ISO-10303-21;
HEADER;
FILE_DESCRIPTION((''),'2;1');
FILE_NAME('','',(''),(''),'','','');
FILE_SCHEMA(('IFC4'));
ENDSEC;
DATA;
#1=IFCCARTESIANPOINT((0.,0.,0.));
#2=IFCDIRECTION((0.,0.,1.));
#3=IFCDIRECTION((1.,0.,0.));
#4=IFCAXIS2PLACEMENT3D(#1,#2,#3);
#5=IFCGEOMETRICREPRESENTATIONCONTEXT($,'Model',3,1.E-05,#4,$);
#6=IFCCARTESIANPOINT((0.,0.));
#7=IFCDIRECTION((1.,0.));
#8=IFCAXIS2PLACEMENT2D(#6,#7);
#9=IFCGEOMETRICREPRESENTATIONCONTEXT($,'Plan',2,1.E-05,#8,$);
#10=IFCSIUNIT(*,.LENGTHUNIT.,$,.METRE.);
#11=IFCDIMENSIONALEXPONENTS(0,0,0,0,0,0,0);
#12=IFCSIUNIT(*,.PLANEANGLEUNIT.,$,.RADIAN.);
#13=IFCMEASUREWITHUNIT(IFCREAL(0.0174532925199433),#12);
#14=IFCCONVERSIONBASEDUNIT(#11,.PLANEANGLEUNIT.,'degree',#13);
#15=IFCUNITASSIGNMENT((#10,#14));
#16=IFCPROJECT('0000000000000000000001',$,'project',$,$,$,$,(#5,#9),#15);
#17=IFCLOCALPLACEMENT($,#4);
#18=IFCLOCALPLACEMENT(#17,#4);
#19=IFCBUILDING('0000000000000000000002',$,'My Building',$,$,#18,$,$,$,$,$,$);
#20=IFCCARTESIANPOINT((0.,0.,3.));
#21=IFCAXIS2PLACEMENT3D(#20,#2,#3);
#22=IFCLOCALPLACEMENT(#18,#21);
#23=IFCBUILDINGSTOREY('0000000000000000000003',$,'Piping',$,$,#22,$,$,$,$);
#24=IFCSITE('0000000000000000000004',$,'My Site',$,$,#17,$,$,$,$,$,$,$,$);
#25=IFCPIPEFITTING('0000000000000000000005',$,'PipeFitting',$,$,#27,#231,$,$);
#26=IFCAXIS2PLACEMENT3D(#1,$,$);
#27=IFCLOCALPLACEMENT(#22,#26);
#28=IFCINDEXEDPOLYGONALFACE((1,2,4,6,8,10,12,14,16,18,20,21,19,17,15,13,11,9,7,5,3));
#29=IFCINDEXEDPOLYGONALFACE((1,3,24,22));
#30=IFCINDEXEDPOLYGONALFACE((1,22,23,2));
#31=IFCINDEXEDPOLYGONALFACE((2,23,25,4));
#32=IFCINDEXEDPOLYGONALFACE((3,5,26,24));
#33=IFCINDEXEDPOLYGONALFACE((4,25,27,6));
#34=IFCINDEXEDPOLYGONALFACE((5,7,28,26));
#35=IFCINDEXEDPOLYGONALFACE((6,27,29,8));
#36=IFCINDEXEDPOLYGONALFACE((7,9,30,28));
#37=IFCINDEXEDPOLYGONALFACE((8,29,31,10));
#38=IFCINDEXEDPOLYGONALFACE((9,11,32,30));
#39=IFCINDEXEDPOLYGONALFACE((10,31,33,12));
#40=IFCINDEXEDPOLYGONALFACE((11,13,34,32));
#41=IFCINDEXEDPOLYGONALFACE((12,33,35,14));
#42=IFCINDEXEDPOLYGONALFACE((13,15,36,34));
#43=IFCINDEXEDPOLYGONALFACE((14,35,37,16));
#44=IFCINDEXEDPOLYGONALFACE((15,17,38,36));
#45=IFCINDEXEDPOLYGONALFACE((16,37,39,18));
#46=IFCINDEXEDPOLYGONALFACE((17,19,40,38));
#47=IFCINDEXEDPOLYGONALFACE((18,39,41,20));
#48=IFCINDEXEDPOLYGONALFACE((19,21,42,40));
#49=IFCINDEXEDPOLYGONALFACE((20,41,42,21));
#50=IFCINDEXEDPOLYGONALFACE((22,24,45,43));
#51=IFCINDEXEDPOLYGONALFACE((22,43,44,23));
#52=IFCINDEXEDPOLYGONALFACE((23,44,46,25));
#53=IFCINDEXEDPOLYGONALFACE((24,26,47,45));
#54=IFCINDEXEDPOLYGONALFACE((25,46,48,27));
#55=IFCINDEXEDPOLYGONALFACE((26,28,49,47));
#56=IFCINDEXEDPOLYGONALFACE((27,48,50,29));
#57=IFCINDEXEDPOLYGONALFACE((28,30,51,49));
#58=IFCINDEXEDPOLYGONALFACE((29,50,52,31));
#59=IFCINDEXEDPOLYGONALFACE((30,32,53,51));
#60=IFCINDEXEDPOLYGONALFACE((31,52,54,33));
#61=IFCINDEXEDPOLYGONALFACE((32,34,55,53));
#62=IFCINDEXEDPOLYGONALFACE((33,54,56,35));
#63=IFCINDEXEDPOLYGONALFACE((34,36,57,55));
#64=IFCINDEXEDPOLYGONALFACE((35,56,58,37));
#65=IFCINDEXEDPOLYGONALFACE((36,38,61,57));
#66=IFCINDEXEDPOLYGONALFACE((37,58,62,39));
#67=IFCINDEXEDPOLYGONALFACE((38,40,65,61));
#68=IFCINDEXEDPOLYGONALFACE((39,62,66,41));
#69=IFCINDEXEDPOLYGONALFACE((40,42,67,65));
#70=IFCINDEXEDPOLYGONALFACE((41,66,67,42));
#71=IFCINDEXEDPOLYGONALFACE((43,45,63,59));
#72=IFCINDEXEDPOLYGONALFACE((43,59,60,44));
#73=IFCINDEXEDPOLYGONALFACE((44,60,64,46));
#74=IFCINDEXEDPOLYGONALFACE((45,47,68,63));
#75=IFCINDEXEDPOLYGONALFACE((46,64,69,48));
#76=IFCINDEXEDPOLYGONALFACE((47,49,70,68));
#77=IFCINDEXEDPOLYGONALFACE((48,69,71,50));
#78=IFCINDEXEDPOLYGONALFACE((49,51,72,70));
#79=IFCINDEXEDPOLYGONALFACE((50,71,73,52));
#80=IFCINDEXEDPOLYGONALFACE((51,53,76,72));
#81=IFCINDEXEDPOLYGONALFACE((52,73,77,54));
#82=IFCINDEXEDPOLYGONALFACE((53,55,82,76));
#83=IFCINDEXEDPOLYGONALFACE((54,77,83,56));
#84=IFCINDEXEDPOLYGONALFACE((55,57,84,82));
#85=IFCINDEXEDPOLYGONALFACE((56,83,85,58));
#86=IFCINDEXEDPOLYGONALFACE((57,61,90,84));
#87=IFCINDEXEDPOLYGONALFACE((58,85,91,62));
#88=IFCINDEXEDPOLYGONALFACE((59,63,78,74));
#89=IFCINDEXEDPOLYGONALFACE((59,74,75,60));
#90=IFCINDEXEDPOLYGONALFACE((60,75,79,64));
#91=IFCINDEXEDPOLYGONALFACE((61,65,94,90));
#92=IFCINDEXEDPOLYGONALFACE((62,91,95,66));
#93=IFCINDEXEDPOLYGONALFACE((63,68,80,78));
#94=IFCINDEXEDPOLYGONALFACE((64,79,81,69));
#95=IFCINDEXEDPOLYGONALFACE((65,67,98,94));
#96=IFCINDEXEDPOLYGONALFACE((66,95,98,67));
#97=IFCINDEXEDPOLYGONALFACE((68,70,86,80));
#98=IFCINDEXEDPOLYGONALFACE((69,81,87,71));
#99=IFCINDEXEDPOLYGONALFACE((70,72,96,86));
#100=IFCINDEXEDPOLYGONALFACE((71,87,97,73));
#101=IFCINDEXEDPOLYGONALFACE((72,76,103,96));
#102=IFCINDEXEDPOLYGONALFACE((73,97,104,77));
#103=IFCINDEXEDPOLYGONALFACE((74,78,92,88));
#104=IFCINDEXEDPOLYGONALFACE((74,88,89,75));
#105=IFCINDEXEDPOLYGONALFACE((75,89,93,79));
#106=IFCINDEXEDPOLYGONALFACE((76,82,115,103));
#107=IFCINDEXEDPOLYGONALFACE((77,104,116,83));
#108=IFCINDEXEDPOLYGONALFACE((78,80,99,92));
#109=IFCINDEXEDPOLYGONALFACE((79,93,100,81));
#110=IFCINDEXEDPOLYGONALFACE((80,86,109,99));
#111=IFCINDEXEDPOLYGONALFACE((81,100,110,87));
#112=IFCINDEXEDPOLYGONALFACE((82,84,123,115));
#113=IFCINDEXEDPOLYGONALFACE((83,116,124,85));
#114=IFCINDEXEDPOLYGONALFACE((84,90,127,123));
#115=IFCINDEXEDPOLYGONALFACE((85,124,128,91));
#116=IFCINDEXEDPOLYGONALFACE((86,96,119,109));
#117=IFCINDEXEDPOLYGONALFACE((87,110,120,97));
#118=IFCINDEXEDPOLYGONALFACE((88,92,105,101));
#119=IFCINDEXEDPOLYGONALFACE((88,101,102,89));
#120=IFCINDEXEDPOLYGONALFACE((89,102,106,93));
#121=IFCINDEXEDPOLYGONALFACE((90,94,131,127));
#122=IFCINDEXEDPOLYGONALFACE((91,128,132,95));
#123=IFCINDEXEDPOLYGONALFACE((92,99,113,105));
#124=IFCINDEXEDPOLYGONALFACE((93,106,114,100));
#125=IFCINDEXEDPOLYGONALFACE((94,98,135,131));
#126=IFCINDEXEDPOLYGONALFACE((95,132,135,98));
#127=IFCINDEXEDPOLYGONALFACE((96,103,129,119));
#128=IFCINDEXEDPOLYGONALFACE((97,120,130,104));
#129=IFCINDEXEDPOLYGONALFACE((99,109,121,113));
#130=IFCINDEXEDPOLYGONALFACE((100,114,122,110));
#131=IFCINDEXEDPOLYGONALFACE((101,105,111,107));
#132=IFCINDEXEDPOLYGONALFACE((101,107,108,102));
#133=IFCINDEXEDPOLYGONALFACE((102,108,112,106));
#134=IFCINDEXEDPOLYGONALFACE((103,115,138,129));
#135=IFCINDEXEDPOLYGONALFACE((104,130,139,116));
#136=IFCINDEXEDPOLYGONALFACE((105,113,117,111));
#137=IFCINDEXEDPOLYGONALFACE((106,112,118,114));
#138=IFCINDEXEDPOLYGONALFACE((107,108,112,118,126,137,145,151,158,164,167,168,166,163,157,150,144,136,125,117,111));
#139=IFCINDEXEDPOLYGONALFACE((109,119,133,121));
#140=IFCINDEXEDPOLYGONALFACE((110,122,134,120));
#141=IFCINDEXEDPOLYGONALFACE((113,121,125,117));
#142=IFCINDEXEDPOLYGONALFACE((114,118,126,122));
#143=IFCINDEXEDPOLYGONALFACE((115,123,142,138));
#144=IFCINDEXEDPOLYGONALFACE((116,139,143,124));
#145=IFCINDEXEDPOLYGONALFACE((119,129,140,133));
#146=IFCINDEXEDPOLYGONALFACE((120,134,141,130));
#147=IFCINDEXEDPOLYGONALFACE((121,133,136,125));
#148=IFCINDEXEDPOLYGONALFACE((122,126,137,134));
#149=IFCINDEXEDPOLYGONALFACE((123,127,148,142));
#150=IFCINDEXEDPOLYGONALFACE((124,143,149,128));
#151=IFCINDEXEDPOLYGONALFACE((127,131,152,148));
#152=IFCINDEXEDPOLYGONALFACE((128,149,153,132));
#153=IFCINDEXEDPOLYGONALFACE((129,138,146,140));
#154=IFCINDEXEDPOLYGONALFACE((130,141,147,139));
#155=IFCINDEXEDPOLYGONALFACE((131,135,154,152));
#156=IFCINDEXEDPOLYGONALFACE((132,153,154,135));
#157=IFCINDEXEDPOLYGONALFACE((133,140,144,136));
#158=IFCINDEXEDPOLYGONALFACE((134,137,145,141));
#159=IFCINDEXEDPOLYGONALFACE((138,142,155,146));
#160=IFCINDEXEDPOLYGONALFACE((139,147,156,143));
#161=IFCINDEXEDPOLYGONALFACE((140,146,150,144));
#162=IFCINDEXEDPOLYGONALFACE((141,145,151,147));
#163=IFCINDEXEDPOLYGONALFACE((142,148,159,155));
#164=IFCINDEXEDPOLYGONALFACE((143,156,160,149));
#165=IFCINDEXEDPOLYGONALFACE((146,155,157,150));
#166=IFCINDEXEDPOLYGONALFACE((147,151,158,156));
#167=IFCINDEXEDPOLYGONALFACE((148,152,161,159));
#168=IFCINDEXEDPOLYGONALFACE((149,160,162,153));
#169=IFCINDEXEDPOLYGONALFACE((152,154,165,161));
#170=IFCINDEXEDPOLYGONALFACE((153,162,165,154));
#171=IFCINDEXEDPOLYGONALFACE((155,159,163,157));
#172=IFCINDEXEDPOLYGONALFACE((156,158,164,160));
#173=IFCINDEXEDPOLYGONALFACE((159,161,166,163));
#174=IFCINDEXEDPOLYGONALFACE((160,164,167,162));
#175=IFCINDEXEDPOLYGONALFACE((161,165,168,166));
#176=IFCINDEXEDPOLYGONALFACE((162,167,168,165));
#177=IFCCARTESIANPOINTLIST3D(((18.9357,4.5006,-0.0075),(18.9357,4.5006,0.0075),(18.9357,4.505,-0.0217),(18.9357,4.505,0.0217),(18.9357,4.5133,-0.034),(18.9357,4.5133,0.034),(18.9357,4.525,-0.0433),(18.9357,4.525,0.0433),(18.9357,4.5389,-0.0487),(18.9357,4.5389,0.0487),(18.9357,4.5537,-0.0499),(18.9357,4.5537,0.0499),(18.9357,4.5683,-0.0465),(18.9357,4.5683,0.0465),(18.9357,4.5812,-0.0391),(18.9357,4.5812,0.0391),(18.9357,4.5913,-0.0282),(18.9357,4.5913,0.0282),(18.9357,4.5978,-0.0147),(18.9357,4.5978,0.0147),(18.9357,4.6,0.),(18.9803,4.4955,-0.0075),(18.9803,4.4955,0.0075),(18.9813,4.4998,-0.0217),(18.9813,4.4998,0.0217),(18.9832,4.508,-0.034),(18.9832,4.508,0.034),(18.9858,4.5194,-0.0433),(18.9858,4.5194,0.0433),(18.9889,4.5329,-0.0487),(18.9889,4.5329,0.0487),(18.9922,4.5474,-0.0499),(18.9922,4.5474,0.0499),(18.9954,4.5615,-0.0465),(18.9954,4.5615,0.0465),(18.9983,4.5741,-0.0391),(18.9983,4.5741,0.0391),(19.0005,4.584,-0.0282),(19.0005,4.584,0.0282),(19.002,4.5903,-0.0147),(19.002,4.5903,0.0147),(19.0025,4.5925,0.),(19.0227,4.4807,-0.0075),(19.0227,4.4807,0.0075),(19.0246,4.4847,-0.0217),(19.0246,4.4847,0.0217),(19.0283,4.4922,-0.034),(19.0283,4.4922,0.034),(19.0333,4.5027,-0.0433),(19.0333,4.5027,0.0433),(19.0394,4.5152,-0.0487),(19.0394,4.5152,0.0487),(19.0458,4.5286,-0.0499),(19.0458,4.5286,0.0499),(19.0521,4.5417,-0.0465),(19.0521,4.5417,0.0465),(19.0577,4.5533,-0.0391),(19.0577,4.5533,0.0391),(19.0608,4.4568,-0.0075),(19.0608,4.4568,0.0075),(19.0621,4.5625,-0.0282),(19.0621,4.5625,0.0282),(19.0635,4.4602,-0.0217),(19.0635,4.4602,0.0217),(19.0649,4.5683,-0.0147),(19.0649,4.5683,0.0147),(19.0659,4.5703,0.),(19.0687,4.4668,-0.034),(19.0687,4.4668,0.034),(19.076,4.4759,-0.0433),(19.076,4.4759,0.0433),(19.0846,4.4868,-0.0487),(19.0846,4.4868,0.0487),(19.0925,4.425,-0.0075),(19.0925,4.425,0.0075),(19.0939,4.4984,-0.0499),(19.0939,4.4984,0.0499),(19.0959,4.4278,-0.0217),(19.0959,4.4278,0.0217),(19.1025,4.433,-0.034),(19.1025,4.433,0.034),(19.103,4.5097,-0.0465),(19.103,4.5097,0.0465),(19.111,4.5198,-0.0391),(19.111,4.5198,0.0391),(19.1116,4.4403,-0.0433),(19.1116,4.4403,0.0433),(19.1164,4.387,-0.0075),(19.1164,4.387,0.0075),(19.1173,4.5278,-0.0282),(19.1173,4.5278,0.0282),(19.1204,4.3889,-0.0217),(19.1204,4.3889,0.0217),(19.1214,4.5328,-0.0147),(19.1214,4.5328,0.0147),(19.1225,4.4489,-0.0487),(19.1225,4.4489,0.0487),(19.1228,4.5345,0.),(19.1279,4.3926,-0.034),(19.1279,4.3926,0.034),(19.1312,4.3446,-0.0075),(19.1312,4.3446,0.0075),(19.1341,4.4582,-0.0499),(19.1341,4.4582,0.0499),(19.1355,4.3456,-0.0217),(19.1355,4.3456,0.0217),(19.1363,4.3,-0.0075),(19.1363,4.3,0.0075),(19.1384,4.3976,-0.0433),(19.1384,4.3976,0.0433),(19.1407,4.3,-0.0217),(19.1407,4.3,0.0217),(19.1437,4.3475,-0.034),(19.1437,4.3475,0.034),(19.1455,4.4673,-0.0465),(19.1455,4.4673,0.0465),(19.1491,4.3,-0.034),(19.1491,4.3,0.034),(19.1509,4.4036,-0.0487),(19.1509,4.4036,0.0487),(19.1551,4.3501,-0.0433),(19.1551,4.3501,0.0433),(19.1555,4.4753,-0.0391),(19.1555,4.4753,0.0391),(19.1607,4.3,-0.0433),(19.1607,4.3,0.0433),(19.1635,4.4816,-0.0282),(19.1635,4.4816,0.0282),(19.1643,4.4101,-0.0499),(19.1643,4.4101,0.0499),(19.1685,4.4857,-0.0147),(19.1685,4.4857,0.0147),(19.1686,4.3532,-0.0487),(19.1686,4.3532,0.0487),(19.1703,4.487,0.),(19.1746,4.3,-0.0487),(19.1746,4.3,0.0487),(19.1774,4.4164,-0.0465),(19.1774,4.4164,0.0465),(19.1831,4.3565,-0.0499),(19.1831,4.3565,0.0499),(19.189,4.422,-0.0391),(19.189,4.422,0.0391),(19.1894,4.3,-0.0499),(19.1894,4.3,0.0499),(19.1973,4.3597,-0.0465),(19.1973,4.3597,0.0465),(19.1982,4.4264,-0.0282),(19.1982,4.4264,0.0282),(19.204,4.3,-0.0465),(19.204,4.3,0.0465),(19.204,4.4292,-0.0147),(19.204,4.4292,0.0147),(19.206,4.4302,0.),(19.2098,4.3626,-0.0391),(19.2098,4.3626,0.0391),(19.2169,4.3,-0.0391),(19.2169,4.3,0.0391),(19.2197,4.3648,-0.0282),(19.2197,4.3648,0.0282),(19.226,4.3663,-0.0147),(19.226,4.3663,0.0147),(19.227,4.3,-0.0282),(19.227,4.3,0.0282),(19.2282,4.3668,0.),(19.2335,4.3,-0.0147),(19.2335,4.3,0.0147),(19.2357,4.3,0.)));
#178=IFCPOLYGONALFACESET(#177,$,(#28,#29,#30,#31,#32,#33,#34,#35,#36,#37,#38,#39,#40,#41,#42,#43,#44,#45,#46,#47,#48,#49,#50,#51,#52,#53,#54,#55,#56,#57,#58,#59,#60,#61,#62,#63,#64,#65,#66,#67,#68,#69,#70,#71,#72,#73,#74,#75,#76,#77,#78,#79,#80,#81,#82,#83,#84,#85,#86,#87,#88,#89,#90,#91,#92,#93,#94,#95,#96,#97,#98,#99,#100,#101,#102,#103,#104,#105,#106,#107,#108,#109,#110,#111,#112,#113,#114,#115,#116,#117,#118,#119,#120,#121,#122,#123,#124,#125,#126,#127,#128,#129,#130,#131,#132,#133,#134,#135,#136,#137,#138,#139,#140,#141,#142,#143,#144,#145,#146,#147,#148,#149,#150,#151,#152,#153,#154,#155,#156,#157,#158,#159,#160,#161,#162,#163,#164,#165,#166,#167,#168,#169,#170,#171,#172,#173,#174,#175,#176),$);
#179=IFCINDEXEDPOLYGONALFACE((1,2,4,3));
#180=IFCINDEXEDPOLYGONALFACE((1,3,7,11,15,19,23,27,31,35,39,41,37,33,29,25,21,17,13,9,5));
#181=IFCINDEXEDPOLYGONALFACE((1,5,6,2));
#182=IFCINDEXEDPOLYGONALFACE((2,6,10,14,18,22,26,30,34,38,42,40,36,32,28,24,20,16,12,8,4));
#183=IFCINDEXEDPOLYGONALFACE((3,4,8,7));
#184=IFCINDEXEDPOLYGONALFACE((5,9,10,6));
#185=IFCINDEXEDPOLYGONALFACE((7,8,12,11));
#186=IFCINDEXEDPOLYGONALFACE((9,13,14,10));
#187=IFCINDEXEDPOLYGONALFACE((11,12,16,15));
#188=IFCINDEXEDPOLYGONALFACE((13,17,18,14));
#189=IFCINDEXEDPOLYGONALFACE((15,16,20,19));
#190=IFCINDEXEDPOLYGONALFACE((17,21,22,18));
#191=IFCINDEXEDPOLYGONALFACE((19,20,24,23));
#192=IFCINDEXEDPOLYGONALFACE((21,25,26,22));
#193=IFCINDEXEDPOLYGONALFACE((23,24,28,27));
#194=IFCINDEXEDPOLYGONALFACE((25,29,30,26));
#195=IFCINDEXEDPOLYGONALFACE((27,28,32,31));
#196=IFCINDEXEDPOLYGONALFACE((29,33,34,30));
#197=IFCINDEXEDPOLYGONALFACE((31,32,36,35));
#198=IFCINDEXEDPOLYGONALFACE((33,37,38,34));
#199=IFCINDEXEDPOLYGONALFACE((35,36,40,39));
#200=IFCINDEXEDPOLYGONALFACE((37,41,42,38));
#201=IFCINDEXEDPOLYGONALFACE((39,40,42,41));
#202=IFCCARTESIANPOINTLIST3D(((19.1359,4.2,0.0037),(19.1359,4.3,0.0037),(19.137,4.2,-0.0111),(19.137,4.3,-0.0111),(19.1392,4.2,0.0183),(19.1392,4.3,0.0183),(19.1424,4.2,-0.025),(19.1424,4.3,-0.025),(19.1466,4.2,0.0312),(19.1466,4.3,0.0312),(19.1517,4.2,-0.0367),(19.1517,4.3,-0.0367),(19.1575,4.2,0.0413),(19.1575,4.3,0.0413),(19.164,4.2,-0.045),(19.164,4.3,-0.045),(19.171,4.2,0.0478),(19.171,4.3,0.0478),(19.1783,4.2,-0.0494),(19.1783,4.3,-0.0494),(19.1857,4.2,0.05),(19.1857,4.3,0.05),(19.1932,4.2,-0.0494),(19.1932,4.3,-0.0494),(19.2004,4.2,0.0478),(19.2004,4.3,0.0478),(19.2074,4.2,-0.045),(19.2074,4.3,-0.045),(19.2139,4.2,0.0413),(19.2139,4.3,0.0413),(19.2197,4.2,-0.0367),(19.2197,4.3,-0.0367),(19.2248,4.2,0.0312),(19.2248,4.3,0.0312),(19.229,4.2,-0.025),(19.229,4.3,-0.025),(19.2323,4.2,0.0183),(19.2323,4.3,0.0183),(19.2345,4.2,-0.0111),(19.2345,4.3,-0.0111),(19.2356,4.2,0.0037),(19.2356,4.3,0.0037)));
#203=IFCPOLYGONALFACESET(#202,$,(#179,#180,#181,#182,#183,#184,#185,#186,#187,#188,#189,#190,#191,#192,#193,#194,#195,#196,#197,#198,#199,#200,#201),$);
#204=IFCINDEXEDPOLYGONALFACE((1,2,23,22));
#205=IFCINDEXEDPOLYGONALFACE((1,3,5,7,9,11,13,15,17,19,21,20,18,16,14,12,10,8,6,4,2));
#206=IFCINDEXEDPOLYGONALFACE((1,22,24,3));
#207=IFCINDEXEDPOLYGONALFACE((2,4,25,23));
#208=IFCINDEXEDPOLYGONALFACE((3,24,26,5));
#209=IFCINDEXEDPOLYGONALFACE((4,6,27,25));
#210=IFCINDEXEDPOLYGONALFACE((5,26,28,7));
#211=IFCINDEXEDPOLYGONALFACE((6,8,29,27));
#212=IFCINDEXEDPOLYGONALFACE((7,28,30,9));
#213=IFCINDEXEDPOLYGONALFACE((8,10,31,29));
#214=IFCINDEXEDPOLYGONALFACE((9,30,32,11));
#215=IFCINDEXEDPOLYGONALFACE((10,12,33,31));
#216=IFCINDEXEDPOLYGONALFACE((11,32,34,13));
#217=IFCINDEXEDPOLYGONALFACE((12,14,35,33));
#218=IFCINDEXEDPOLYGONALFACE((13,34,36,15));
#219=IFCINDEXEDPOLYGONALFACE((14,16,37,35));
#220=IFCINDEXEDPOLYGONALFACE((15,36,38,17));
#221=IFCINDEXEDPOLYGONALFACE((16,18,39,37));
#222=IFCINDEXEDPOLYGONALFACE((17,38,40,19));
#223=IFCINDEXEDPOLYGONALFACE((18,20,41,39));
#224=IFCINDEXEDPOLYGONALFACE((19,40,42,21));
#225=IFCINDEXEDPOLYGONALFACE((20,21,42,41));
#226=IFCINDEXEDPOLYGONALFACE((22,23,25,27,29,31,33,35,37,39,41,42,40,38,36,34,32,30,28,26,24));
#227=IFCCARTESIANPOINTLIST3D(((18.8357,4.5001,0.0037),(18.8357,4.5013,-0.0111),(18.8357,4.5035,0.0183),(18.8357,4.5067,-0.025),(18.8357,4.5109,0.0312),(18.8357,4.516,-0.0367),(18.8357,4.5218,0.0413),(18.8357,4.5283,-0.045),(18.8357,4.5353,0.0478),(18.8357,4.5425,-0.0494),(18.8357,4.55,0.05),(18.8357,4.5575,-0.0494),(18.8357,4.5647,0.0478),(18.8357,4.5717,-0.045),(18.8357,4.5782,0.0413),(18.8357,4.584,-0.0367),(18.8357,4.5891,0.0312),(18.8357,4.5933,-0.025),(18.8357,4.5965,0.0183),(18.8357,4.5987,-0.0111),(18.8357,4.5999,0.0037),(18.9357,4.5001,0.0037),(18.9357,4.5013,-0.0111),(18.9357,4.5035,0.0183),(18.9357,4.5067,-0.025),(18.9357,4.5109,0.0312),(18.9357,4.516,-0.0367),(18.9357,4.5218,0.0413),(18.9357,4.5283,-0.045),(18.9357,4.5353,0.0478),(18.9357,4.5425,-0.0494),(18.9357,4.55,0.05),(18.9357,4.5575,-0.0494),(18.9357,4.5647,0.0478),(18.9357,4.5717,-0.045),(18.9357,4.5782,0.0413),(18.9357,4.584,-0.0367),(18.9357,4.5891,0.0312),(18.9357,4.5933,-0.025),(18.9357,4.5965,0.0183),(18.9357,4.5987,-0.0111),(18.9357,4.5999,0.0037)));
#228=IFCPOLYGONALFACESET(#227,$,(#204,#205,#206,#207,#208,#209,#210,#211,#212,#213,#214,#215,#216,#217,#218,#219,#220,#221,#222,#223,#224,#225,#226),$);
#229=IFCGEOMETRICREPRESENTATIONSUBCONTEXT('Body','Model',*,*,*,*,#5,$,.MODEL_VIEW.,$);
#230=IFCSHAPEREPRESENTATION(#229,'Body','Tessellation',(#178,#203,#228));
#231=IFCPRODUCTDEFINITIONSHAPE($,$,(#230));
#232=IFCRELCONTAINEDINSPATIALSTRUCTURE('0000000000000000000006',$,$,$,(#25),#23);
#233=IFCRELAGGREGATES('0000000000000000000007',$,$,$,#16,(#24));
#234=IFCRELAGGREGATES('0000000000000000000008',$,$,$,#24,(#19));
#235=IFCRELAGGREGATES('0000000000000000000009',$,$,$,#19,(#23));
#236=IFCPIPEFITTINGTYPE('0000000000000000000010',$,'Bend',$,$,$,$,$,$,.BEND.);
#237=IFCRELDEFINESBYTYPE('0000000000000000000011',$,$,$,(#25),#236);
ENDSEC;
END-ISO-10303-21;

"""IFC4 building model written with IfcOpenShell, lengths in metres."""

from ifc_helpers import new_model, entity, si_unit, converted_unit, frame, origin_with_axes, origin_2d_with_axis, place, context, subcontext, project, spatial, line, indexed_curve, circle, outline, extrude, source, transform, mapped, type_object, type_shapes, element, save


model = new_model("IFC4")

# Units and contexts
model_context = context("Model", 3, precision=1e-05, world=origin_with_axes())
plan_context = context("Plan", 2, precision=1e-05, world=origin_2d_with_axis())
body_context = subcontext(model_context, "Body", "Model", "MODEL_VIEW")
ifc_project = project(units=[si_unit("LENGTHUNIT", "METRE"), converted_unit("PLANEANGLEUNIT", "degree", entity("IfcReal", 0.0174532925199433), si_unit("PLANEANGLEUNIT", "RADIAN"), dimensions=[0, 0, 0, 0, 0, 0, 0])], contexts=[model_context, plan_context])

# Site, building, storey
site_placement = place(None, origin_with_axes())
site = spatial("IfcSite", under=ifc_project, at=site_placement, Name="My Site")
building_placement = place(site_placement, origin_with_axes())
building = spatial("IfcBuilding", under=site, at=building_placement, Name="My Building")
storey_placement = place(building_placement, frame((0.0, 0.0, 3.0), z_axis=(0.0, 0.0, 1.0), x_axis=(1.0, 0.0, 0.0)))
storey = spatial("IfcBuildingStorey", under=building, at=storey_placement, Name="Piping")

# Pipe fitting, opening
pipe_fitting_type = type_object("IfcPipeFittingType", Name="Bend", PredefinedType="BEND")
shared_shape = source(origin_with_axes(), body_context, "Body", "SolidModel", [
    entity("IfcSweptDiskSolid", entity("IfcIndexedPolyCurve", entity("IfcCartesianPointList3D", [[0.0, 0.0, 0.1], [0.0, -0.0732, 0.2768], [0.0, -0.25, 0.35]]), [entity("IfcArcIndex", [1, 2, 3])]), 0.05),
    extrude(circle(Radius=0.05), origin_with_axes(), (0.0, 0.0, 1.0), 0.1),
    extrude(circle(Radius=0.05), frame((0.0, -0.25, 0.35), z_axis=(0.0, -1.0, 0.0), x_axis=(1.0, 0.0, 0.0)), (0.0, 0.0, 1.0), 0.1),
])
type_shapes(pipe_fitting_type, [shared_shape])
pipe_fitting_1_placement = place(storey_placement, frame((19.1857, 4.2, 0.0), z_axis=(0.0, 1.0, 0.0), x_axis=(0.0, 0.0, 1.0)))
pipe_fitting_1 = element("IfcPipeFitting", 1, at=pipe_fitting_1_placement, inside=storey, type_object=pipe_fitting_type, Name="PipeFitting", context=body_context, shape_type="MappedRepresentation", body=[
    mapped(shared_shape, transform((0.0, 0.0, 0.0), x_axis=(1.0, 0.0, 0.0), y_axis=(0.0, 1.0, 0.0), z_axis=(0.0, 0.0, 1.0), scale=1.0)),
])
opening_1_placement = place(pipe_fitting_1_placement, frame((-3.0, -19.1857, -4.2), z_axis=(1.0, 0.0, 0.0), x_axis=(0.0, 1.0, 0.0)))
element("IfcOpeningElement", 2, at=opening_1_placement, cuts=pipe_fitting_1, PredefinedType="OPENING", context=body_context, shape_type="SweptSolid", body=[
    extrude(outline(indexed_curve([(0.0, 0.0), (0.5, 0.0), (0.5, 0.5), (0.0, 0.5)], segments=[line(1, 2, 3, 4, 1)])), origin_with_axes(), (0.0, 0.0, 1.0), 0.5),
])

save(model, "model.ifc")
